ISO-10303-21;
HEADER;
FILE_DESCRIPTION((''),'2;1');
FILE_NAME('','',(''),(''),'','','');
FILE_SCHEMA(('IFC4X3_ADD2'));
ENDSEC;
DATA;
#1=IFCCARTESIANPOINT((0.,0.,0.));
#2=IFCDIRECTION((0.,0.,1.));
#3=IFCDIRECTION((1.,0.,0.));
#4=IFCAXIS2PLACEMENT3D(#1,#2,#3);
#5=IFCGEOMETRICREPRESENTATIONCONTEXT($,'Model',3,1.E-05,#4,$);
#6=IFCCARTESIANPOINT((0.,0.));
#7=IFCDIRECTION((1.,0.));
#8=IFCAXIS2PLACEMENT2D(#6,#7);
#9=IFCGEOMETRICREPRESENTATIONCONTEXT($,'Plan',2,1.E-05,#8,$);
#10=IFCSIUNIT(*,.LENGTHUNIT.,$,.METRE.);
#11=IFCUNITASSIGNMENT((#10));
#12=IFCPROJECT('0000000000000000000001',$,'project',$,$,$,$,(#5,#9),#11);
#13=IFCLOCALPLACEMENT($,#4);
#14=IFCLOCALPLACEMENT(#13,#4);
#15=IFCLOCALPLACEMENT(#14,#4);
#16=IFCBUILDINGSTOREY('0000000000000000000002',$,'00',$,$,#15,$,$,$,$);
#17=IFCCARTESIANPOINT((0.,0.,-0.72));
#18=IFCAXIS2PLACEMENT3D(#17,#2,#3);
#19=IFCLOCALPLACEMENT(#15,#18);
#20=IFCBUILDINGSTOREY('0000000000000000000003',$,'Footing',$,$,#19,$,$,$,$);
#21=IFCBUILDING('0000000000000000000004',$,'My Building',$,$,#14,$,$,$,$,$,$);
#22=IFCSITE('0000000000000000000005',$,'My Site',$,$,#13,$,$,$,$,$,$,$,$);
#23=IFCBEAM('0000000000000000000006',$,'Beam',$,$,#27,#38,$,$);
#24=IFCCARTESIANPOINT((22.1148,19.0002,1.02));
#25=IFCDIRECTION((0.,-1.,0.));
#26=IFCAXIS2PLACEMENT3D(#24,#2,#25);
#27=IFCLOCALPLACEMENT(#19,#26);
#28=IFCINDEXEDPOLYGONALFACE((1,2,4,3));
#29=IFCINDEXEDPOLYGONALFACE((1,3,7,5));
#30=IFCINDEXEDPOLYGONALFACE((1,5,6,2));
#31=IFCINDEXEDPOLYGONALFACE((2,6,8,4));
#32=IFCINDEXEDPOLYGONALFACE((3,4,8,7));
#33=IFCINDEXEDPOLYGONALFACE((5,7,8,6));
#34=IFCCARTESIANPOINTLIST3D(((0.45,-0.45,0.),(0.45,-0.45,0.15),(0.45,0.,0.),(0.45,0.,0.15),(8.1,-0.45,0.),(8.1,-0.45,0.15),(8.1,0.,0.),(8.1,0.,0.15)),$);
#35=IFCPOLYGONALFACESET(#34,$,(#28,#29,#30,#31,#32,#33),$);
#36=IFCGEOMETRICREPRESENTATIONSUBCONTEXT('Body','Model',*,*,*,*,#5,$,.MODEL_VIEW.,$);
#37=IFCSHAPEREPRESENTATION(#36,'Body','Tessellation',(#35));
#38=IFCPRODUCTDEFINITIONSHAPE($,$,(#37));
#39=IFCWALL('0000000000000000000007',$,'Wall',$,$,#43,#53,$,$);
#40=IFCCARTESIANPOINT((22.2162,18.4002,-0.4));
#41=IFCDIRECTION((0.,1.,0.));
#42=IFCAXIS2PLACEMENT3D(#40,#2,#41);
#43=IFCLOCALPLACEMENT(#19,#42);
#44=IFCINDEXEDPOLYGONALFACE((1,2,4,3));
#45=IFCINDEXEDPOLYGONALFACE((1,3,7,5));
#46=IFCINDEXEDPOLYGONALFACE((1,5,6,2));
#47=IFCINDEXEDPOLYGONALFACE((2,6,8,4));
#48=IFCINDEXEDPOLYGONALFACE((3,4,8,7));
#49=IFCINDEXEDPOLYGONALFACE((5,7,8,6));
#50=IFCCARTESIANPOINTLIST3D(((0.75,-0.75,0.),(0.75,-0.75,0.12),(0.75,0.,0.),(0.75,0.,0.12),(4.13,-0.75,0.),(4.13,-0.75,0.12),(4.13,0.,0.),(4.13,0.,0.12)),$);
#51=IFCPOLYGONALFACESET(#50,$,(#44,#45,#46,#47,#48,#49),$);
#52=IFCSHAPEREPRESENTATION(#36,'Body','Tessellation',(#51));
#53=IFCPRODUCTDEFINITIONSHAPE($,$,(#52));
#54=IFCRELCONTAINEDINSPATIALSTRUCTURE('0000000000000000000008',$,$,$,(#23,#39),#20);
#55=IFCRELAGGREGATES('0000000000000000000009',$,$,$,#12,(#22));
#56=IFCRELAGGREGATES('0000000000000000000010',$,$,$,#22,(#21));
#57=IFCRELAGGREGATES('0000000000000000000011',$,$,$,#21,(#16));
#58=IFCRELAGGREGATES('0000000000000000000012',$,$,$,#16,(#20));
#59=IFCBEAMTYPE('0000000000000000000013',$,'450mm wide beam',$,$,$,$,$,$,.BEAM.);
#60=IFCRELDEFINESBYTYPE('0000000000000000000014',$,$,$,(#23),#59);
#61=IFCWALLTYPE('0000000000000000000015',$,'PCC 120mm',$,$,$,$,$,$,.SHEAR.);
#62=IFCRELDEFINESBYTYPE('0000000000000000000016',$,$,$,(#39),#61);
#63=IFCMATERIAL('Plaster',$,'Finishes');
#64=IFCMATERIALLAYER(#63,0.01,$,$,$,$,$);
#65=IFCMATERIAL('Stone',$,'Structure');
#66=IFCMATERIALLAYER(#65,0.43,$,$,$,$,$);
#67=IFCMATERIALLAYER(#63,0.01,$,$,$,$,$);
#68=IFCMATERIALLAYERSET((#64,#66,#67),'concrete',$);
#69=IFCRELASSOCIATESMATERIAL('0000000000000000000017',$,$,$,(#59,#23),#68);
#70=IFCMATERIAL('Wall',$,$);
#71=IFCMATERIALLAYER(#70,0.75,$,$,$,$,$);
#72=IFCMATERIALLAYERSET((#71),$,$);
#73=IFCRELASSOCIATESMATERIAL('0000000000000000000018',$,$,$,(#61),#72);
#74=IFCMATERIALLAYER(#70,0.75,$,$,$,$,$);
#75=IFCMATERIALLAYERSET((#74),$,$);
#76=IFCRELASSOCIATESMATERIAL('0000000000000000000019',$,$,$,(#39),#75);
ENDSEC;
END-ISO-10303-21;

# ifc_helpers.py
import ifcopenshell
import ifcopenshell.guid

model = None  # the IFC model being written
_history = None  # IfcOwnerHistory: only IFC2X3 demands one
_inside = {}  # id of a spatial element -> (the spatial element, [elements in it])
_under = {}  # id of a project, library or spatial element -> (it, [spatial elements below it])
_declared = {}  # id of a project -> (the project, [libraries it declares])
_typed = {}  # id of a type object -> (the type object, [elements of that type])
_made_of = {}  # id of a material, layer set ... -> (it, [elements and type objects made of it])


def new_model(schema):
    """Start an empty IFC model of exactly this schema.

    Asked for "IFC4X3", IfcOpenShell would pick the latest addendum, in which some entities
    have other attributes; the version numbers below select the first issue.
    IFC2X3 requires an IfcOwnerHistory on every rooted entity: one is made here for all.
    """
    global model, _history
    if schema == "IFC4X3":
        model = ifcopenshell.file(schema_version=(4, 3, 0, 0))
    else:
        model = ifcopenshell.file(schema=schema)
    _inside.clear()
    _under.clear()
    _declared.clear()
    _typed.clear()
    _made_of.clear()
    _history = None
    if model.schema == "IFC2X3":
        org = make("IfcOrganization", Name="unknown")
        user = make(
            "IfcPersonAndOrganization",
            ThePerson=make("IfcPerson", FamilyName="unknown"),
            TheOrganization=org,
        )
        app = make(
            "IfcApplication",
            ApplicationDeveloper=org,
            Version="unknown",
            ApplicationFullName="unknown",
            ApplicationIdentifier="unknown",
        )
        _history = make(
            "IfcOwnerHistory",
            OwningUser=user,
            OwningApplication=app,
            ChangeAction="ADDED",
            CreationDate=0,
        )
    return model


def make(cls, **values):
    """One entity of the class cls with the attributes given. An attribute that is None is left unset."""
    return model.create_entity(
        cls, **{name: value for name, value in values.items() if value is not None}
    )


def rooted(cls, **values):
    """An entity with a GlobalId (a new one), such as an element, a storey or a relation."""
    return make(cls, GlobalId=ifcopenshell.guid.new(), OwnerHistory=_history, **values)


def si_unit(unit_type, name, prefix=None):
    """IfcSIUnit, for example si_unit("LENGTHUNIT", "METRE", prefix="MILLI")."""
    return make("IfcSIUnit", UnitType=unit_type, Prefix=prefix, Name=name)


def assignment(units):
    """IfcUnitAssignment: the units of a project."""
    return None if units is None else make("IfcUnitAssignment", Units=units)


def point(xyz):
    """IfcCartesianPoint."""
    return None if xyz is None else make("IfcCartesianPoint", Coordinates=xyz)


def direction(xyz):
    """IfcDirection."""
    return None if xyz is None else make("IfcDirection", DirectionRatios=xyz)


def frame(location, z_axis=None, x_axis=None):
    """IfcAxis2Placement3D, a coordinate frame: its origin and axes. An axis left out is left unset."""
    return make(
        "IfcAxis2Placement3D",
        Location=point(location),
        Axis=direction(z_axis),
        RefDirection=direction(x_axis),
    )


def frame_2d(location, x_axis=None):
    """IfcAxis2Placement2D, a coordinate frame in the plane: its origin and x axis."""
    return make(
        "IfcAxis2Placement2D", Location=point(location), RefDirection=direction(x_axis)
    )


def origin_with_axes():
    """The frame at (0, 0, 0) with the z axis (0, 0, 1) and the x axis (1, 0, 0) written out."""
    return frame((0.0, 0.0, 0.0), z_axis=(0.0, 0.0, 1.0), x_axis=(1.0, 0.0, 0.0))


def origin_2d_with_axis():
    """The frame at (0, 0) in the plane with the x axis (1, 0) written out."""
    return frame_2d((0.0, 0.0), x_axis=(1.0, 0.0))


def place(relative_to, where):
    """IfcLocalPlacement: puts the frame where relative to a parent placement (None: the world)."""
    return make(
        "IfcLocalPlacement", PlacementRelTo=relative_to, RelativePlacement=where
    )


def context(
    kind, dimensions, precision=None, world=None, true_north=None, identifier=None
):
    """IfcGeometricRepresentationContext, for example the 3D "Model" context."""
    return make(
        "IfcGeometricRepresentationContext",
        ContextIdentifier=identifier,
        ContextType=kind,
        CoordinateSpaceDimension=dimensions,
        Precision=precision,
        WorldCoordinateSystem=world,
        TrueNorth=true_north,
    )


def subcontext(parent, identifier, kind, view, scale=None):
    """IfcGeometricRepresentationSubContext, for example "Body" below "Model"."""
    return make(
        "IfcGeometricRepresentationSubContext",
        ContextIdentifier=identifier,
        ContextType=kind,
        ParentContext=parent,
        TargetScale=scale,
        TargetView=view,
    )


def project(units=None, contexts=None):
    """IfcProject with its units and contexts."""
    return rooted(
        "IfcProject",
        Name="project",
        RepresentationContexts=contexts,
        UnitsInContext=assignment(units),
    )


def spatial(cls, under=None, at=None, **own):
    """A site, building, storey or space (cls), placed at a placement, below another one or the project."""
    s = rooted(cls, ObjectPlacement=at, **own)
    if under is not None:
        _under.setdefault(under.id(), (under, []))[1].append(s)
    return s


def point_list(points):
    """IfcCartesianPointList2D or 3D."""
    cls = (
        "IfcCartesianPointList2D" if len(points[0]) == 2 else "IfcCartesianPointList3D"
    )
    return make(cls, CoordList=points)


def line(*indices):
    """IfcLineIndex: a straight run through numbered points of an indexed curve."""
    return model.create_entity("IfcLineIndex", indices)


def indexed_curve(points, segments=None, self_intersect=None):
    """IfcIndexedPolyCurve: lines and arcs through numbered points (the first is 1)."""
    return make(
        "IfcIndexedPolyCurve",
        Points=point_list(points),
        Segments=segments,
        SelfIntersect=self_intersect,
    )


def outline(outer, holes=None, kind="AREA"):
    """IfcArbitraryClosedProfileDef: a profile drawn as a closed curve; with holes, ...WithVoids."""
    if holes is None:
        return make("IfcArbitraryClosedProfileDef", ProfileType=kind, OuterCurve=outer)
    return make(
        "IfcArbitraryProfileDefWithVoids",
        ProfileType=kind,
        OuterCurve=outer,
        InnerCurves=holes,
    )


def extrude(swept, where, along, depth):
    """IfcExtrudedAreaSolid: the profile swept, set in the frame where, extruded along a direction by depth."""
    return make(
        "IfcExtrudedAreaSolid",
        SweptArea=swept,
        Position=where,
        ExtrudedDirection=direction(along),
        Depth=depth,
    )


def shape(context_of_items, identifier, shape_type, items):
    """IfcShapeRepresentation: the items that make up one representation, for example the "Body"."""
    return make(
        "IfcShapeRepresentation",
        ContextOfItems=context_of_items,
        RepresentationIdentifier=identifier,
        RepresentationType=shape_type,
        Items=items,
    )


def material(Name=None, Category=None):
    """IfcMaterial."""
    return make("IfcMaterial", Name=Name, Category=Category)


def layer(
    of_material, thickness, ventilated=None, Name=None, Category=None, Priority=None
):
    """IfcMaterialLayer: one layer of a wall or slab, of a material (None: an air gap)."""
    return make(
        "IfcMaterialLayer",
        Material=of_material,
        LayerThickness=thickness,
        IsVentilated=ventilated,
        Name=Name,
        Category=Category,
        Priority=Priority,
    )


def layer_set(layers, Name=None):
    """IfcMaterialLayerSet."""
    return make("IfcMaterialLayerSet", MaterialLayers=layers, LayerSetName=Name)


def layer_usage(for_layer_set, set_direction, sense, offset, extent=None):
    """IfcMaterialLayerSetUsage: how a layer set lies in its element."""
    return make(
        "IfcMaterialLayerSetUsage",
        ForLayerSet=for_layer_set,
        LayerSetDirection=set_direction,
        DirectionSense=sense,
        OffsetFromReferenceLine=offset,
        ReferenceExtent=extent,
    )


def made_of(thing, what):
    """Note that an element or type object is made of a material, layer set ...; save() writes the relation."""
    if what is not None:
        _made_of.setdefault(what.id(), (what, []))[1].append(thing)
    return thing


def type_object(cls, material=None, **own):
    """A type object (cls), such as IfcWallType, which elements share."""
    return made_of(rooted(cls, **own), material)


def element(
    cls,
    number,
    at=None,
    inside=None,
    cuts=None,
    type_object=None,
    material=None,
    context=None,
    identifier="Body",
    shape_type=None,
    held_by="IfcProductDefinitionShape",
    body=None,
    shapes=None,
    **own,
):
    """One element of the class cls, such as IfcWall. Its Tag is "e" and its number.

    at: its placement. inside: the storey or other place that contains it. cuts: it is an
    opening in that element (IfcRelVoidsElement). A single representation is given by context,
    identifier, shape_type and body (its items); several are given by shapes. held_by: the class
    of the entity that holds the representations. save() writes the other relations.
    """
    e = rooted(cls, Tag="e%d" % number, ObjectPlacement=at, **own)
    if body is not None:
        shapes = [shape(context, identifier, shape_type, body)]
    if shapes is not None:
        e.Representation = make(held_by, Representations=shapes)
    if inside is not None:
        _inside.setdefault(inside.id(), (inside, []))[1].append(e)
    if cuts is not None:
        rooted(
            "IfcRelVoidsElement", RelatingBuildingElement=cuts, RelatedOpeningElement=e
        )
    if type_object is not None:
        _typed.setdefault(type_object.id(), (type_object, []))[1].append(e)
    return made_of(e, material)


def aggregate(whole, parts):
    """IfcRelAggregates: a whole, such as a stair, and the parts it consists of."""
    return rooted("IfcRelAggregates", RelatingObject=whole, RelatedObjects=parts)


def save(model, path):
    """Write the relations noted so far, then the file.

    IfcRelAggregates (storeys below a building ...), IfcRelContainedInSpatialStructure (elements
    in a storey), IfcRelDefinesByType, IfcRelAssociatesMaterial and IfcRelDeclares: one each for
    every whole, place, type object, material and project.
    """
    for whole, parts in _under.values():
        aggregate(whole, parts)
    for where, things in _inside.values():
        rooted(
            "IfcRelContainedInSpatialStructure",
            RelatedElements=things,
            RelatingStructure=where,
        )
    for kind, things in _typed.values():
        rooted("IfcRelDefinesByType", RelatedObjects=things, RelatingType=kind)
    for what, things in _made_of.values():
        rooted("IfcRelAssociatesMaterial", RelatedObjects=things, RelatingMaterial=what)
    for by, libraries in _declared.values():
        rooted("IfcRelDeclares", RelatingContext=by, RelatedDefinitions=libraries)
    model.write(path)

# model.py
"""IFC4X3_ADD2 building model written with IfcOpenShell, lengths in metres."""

from ifc_helpers import new_model, si_unit, frame, origin_with_axes, origin_2d_with_axis, place, context, subcontext, project, spatial, line, indexed_curve, outline, extrude, material, layer, layer_set, layer_usage, type_object, element, save


model = new_model("IFC4X3_ADD2")

# Units and contexts
model_context = context("Model", 3, precision=1e-05, world=origin_with_axes())
plan_context = context("Plan", 2, precision=1e-05, world=origin_2d_with_axis())
body_context = subcontext(model_context, "Body", "Model", "MODEL_VIEW")
ifc_project = project(units=[si_unit("LENGTHUNIT", "METRE")], contexts=[model_context, plan_context])

# Site, building, storeys
site_placement = place(None, origin_with_axes())
site = spatial("IfcSite", under=ifc_project, at=site_placement, Name="My Site")
building_placement = place(site_placement, origin_with_axes())
building = spatial("IfcBuilding", under=site, at=building_placement, Name="My Building")
storey_1_placement = place(building_placement, origin_with_axes())
storey_1 = spatial("IfcBuildingStorey", under=building, at=storey_1_placement, Name="00")
storey_2_placement = place(storey_1_placement, frame((0.0, 0.0, -0.72), z_axis=(0.0, 0.0, 1.0), x_axis=(1.0, 0.0, 0.0)))
storey_2 = spatial("IfcBuildingStorey", under=storey_1, at=storey_2_placement, Name="Footing")

# Beam
ifc_material_1 = material(Name="Plaster", Category="Finishes")
ifc_layer_1 = layer(ifc_material_1, 0.01)
ifc_material_2 = material(Name="Stone", Category="Structure")
ifc_layer_2 = layer(ifc_material_2, 0.43)
ifc_layer_3 = layer(ifc_material_1, 0.01)
ifc_layer_set_1 = layer_set([ifc_layer_1, ifc_layer_2, ifc_layer_3], Name="concrete")
beam_type_1 = type_object("IfcBeamType", Name="450mm wide beam", PredefinedType="BEAM", material=ifc_layer_set_1)
ifc_layer_usage_1 = layer_usage(ifc_layer_set_1, "AXIS2", "NEGATIVE", 0.0)
beam_1_placement = place(storey_2_placement, frame((22.1148, 19.0002, 1.02), z_axis=(0.0, 0.0, 1.0), x_axis=(0.0, -1.0, 0.0)))
element("IfcBeam", 1, at=beam_1_placement, inside=storey_2, type_object=beam_type_1, material=ifc_layer_usage_1, Name="Beam", context=body_context, shape_type="SweptSolid", body=[
    extrude(outline(indexed_curve([(0.45, -0.45), (0.45, 0.0), (8.1, 0.0), (8.1, -0.45)], segments=[line(1, 2, 3, 4, 1)])), origin_with_axes(), (0.0, 0.0, 1.0), 0.15),
])

# Wall
ifc_material_3 = material(Name="Wall")
ifc_layer_4 = layer(ifc_material_3, 0.75)
ifc_layer_set_2 = layer_set([ifc_layer_4])
wall_type_1 = type_object("IfcWallType", Name="PCC 120mm", PredefinedType="SHEAR", material=ifc_layer_set_2)
ifc_layer_5 = layer(ifc_material_3, 0.75)
ifc_layer_set_3 = layer_set([ifc_layer_5])
ifc_layer_usage_2 = layer_usage(ifc_layer_set_3, "AXIS2", "NEGATIVE", 0.0)
wall_1_placement = place(storey_2_placement, frame((22.2162, 18.4002, -0.4), z_axis=(0.0, 0.0, 1.0), x_axis=(0.0, 1.0, 0.0)))
element("IfcWall", 2, at=wall_1_placement, inside=storey_2, type_object=wall_type_1, material=ifc_layer_usage_2, Name="Wall", context=body_context, shape_type="SweptSolid", body=[
    extrude(outline(indexed_curve([(0.75, -0.75), (0.75, 0.0), (4.13, 0.0), (4.13, -0.75)], segments=[line(1, 2, 3, 4, 1)])), origin_with_axes(), (0.0, 0.0, 1.0), 0.12),
])

save(model, "model.ifc")
